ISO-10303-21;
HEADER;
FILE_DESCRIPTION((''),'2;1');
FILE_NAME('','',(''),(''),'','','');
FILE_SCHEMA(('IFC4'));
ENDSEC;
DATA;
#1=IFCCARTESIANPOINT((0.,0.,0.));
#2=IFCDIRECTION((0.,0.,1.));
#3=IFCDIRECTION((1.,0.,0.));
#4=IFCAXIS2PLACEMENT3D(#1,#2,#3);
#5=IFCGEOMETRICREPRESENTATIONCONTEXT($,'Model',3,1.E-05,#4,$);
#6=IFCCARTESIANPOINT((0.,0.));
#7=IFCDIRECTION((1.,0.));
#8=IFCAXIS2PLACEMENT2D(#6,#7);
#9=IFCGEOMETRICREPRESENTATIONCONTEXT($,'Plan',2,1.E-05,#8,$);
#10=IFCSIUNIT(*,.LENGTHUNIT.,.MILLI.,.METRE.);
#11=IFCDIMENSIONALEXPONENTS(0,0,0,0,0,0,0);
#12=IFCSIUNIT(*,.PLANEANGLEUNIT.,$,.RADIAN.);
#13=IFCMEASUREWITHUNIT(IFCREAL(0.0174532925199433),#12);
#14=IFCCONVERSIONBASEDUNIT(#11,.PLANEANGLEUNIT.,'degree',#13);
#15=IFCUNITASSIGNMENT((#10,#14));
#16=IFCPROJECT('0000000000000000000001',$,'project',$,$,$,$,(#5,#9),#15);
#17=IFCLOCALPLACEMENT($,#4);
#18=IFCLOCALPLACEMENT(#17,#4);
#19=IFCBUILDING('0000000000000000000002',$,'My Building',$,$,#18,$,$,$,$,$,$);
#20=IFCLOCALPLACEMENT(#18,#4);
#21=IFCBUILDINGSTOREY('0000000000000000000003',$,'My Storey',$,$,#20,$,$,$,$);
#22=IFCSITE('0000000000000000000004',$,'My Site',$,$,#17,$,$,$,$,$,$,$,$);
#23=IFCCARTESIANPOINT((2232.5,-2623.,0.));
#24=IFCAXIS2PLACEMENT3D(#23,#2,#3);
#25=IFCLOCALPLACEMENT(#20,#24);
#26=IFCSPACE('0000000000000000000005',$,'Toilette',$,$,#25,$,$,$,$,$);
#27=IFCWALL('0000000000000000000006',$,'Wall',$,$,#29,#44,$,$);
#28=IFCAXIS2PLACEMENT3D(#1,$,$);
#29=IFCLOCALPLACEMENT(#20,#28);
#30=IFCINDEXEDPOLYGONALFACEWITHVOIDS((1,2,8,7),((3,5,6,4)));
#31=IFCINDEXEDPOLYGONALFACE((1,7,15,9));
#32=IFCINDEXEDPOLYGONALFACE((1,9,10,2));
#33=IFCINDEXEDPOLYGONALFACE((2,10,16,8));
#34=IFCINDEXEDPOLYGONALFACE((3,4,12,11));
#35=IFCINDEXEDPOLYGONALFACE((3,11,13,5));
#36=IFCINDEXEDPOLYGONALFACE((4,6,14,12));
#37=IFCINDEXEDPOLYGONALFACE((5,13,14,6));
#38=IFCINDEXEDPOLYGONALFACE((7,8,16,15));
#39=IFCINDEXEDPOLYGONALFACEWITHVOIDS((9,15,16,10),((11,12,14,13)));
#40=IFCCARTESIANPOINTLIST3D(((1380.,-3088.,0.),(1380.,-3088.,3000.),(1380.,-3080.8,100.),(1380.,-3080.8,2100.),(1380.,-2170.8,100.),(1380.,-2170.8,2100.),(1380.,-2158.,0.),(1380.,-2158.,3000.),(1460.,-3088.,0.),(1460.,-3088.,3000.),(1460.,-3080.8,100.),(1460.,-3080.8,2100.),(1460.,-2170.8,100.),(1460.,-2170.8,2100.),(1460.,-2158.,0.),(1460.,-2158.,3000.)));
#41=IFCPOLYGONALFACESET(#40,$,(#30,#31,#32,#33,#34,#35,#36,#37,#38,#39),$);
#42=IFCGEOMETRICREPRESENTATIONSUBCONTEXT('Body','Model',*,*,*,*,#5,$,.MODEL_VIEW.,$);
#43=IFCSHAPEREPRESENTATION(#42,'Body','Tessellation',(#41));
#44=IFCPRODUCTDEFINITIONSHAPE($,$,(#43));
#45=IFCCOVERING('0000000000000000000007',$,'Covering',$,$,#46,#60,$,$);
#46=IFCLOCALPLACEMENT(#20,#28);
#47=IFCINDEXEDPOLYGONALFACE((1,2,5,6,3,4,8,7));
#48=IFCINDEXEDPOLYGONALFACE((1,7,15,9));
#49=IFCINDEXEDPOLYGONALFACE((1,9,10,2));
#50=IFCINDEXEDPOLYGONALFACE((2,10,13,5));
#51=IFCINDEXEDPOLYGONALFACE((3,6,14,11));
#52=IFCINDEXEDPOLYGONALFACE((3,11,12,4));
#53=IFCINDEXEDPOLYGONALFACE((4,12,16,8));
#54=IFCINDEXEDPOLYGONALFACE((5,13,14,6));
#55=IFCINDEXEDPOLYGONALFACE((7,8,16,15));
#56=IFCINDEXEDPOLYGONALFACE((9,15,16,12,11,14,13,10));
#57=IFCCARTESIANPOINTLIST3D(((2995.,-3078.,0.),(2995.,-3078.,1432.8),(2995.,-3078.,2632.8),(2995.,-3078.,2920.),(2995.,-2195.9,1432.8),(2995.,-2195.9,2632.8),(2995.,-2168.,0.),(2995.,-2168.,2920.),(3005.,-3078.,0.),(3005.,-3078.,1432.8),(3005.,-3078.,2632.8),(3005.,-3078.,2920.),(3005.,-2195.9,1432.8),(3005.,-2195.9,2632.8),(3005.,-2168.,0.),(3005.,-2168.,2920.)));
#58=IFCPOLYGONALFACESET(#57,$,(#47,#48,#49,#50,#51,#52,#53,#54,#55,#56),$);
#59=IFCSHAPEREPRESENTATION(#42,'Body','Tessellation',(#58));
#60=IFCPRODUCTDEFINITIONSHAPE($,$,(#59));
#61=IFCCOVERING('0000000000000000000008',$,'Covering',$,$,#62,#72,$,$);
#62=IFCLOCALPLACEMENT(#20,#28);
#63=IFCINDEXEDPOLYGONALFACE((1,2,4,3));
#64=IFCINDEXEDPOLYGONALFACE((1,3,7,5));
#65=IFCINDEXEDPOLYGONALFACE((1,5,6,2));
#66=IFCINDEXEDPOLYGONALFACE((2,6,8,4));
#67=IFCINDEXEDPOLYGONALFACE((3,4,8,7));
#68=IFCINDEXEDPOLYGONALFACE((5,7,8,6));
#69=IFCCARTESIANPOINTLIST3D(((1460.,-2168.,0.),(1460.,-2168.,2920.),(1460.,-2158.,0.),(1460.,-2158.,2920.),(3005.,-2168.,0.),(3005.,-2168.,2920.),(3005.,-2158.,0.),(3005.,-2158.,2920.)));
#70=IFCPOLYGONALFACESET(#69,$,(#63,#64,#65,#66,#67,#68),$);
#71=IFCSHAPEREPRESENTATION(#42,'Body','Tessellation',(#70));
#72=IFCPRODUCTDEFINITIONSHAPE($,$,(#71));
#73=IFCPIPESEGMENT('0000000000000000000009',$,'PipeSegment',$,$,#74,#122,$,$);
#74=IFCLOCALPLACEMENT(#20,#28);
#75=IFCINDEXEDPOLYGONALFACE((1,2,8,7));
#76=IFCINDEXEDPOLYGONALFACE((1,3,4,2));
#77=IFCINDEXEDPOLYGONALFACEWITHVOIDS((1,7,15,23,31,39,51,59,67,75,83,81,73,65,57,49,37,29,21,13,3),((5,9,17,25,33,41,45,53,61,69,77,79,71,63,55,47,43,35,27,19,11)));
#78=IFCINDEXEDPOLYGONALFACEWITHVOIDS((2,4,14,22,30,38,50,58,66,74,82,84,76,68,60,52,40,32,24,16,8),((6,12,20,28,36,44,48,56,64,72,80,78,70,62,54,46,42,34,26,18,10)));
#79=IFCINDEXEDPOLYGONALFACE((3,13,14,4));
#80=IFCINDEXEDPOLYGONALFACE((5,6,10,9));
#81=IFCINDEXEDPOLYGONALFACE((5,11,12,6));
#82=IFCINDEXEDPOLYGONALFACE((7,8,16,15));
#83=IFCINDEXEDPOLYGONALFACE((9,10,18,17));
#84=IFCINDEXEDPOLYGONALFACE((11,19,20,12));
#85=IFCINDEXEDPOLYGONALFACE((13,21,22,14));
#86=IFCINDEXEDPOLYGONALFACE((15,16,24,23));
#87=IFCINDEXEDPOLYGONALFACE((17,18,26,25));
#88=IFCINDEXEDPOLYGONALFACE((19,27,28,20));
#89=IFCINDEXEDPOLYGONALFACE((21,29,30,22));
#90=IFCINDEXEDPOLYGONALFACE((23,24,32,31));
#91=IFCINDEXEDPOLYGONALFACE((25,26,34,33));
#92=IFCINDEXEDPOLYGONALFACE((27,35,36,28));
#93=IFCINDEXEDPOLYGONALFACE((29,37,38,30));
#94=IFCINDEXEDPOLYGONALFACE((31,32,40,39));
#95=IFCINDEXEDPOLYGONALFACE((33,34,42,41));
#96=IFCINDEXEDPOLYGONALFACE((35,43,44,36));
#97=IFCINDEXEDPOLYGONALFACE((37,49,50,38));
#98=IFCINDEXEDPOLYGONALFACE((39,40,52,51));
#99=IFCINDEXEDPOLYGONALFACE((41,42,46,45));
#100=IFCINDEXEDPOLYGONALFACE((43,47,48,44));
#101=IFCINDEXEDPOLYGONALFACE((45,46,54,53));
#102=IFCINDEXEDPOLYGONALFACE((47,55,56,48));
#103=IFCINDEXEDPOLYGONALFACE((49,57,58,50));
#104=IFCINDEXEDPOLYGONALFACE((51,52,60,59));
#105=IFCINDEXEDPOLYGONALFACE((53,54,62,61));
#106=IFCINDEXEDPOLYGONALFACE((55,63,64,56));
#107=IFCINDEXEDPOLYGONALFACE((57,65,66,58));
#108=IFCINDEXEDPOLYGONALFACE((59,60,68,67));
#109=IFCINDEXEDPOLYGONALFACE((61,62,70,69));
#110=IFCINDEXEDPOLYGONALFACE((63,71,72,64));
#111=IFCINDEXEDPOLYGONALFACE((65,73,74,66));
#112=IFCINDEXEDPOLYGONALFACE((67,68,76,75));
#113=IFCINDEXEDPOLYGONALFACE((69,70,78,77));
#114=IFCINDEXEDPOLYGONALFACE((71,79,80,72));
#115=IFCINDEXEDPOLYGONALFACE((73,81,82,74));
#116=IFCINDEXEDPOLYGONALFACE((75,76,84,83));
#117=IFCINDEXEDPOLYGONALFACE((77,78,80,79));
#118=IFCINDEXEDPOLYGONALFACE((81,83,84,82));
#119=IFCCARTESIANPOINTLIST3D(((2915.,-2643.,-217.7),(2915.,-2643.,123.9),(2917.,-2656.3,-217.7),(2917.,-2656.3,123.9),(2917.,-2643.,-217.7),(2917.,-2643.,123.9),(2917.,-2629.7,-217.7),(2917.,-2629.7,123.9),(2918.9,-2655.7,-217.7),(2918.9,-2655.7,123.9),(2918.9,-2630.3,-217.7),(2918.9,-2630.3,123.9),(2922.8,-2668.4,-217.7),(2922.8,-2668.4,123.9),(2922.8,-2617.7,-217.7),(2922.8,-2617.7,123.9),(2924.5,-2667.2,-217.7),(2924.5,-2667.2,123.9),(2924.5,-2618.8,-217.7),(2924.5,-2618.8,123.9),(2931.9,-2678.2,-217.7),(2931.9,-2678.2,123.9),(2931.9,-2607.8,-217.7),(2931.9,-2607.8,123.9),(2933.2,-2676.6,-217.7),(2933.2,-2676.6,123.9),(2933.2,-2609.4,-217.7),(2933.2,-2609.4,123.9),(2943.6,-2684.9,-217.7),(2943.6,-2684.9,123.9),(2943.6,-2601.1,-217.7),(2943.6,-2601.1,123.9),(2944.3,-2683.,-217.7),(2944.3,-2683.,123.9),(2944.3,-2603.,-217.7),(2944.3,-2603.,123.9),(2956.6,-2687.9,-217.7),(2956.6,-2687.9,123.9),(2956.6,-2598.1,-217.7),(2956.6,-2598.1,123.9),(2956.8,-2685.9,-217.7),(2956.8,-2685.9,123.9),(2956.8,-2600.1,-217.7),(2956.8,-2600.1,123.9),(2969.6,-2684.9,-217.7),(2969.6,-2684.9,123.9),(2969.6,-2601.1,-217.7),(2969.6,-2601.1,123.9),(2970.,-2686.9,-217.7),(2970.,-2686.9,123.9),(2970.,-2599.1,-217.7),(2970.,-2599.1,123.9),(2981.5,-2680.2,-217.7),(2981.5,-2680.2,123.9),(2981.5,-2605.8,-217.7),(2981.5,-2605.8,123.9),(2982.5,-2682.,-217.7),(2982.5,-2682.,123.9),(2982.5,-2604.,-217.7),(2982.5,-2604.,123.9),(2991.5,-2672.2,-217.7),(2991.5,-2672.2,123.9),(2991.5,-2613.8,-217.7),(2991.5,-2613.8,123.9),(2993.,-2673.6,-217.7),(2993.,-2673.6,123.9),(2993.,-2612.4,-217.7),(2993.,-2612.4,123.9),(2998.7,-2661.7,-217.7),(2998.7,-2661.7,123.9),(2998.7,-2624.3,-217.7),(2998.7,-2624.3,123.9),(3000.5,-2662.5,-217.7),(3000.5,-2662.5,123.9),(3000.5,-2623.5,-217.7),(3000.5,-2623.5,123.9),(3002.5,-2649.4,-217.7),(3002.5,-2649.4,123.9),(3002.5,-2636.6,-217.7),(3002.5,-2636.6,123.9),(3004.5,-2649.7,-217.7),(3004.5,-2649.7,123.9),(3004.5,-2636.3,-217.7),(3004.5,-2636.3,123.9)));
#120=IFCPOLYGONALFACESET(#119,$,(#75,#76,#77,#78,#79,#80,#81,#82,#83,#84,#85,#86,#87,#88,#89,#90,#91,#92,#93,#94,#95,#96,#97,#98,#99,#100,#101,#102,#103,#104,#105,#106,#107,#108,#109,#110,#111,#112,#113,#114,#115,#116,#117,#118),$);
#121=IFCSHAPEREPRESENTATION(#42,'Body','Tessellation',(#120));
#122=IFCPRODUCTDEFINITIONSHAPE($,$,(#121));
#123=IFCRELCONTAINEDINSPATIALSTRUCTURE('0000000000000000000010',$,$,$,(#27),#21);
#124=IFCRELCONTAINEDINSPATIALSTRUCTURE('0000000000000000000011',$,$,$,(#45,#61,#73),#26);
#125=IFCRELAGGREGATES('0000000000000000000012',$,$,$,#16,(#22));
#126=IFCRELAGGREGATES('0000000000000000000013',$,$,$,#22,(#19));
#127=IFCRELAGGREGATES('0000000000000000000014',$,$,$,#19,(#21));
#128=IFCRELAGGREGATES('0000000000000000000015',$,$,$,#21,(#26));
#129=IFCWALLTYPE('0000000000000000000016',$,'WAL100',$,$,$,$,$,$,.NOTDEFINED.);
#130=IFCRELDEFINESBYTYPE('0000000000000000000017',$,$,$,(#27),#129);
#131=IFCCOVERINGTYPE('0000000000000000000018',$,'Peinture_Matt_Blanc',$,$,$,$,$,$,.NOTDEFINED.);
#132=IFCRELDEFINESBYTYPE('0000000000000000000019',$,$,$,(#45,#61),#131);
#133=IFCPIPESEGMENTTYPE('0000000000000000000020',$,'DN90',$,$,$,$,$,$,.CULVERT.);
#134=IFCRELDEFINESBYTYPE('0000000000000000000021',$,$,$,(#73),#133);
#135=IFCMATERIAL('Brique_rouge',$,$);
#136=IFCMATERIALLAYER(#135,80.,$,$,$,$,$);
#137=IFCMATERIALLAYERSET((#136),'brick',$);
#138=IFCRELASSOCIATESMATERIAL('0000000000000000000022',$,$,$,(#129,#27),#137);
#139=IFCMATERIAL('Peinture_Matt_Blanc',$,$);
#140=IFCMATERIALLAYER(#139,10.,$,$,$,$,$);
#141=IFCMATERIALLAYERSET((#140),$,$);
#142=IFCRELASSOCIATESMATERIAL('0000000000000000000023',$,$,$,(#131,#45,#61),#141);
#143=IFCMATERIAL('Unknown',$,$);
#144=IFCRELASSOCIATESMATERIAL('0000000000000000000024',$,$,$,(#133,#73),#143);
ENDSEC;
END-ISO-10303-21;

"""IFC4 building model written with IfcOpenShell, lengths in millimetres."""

from ifc_helpers import new_model, entity, si_unit, converted_unit, frame, origin_with_axes, origin_2d_with_axis, place, context, subcontext, project, spatial, line, indexed_curve, hollow_circle, outline, extrude, clip, halfspace, source, transform, mapped, material, layer, layer_set, layer_usage, material_profile, profile_set, profile_usage, type_object, element, save


model = new_model("IFC4")

# Units and contexts
model_context = context("Model", 3, precision=1e-05, world=origin_with_axes())
plan_context = context("Plan", 2, precision=1e-05, world=origin_2d_with_axis())
body_context = subcontext(model_context, "Body", "Model", "MODEL_VIEW")
ifc_project = project(units=[si_unit("LENGTHUNIT", "METRE", prefix="MILLI"), converted_unit("PLANEANGLEUNIT", "degree", entity("IfcReal", 0.0174532925199433), si_unit("PLANEANGLEUNIT", "RADIAN"), dimensions=[0, 0, 0, 0, 0, 0, 0])], contexts=[model_context, plan_context])

# Site, building, storey
site_placement = place(None, origin_with_axes())
site = spatial("IfcSite", under=ifc_project, at=site_placement, Name="My Site")
building_placement = place(site_placement, origin_with_axes())
building = spatial("IfcBuilding", under=site, at=building_placement, Name="My Building")
storey_placement = place(building_placement, origin_with_axes())
storey = spatial("IfcBuildingStorey", under=building, at=storey_placement, Name="My Storey")

# Shared definitions
ifc_material_1 = material(Name="Unknown")

# Wall, opening
ifc_material_2 = material(Name="Brique_rouge")
ifc_layer_1 = layer(ifc_material_2, 80.0)
ifc_layer_set_1 = layer_set([ifc_layer_1], Name="brick")
ifc_layer_usage_1 = layer_usage(ifc_layer_set_1, "AXIS2", "POSITIVE", 0.0)
wall_type = type_object("IfcWallType", Name="WAL100", PredefinedType="NOTDEFINED", material=ifc_layer_set_1)
wall_placement = place(storey_placement, frame((1380.0, -2158.0, 0.0), z_axis=(0.0, 0.0, 1.0), x_axis=(-0.000001, -1.0, 0.0)))
wall = element("IfcWall", 1, at=wall_placement, inside=storey, type_object=wall_type, material=ifc_layer_usage_1, Name="Wall", context=body_context, shape_type="SweptSolid", body=[
    extrude(outline(indexed_curve([(0.0, 0.0), (0.0, 80.0), (930.0, 80.0), (930.0, 0.0), (0.0, 0.0)], self_intersect=False)), origin_with_axes(), (0.0, 0.0, 1.0), 3000.0),
])
shared_shape_1 = source(origin_with_axes(), body_context, "Body", "SweptSolid", [
    extrude(outline(indexed_curve([(0.0, 0.0), (910.0, 0.0), (910.0, 2000.0), (0.0, 2000.0)], segments=[line(3, 2), line(2, 1), line(1, 4), line(4, 3)], self_intersect=False)), frame((0.0, -100.0, 0.0), z_axis=(0.0, -1.0, 0.0), x_axis=(1.0, 0.0, 0.0)), (0.0, 0.0, -1.0), 280.0),
])
opening_1_placement = place(wall_placement, frame((12.8, -13.4, 100.0), z_axis=(0.0, 0.0, 1.0), x_axis=(1.0, 0.0, 0.0)))
element("IfcOpeningElement", 2, at=opening_1_placement, cuts=wall, PredefinedType="OPENING", context=body_context, shape_type="MappedRepresentation", body=[
    mapped(shared_shape_1, transform((0.0, 0.0, 0.0), x_axis=(1.0, 0.0, 0.0), y_axis=(0.0, 1.0, 0.0), z_axis=(0.0, 0.0, 1.0), scale=1.0)),
])

# Shared definitions
space_1_placement = place(storey_placement, frame((2232.5, -2623.0, 0.0), z_axis=(0.0, 0.0, 1.0), x_axis=(1.0, 0.0, 0.0)))
space_1 = spatial("IfcSpace", under=storey, at=space_1_placement, Name="Toilette")

# Covering, opening
ifc_material_3 = material(Name="Peinture_Matt_Blanc")
ifc_layer_2 = layer(ifc_material_3, 10.0)
ifc_layer_set_2 = layer_set([ifc_layer_2])
ifc_layer_usage_2 = layer_usage(ifc_layer_set_2, "AXIS2", "POSITIVE", 0.0)
covering_type_1 = type_object("IfcCoveringType", Name="Peinture_Matt_Blanc", PredefinedType="NOTDEFINED", material=ifc_layer_set_2)
covering_1_placement = place(space_1_placement, frame((762.5, 455.0, 0.0), z_axis=(0.0, 0.0, 1.0), x_axis=(-0.000001, -1.0, 0.0)))
covering_1 = element("IfcCovering", 3, at=covering_1_placement, inside=space_1, type_object=covering_type_1, material=ifc_layer_usage_2, Name="Covering", context=body_context, shape_type="Clipping", body=[
    clip(extrude(outline(indexed_curve([(0.0, 0.0), (0.0, 10.0), (910.0, 10.0), (910.0, 0.0), (0.0, 0.0)], self_intersect=False)), origin_with_axes(), (0.0, 0.0, 1.0), 2920.0), halfspace(frame((0.0, 0.0, 2920.0), z_axis=(0.0, 0.0, 1.0), x_axis=(-1.0, 0.0, 0.0)), False)),
])
shared_shape_2 = source(origin_with_axes(), body_context, "Body", "SweptSolid", [
    extrude(outline(indexed_curve([(0.0, 0.0), (900.0, 0.0), (900.0, 1200.0), (0.0, 1200.0)], segments=[line(1, 2, 3, 4, 1)])), frame((0.0, -600.0, 0.0), z_axis=(0.0, -1.0, 0.0), x_axis=(1.0, 0.0, 0.0)), (0.0, 0.0, -1.0), 1200.0),
])
opening_2_placement = place(covering_1_placement, frame((27.9, 10.0, 1432.8), z_axis=(0.0, 0.0, 1.0), x_axis=(1.0, 0.0, 0.0)))
element("IfcOpeningElement", 4, at=opening_2_placement, cuts=covering_1, PredefinedType="OPENING", context=body_context, shape_type="MappedRepresentation", body=[
    mapped(shared_shape_2, transform((0.0, 0.0, 0.0), x_axis=(1.0, 0.0, 0.0), y_axis=(0.0, 1.0, 0.0), z_axis=(0.0, 0.0, 1.0), scale=1.0)),
])

# Covering
ifc_layer_usage_3 = layer_usage(ifc_layer_set_2, "AXIS2", "POSITIVE", 0.0)
covering_2_placement = place(space_1_placement, frame((772.5, 465.0, 0.0), z_axis=(0.0, 0.0, 1.0), x_axis=(-1.0, 0.000002, 0.0)))
element("IfcCovering", 5, at=covering_2_placement, inside=space_1, type_object=covering_type_1, material=ifc_layer_usage_3, Name="Covering", context=body_context, shape_type="Clipping", body=[
    clip(extrude(outline(indexed_curve([(0.0, 0.0), (0.0, 10.0), (1545.0, 10.0), (1545.0, 0.0), (0.0, 0.0)], self_intersect=False)), origin_with_axes(), (0.0, 0.0, 1.0), 2920.0), halfspace(frame((0.0, 0.0, 2920.0), z_axis=(0.0, 0.0, 1.0), x_axis=(-1.0, 0.0, 0.0)), False)),
])

# Pipe segment
ifc_material_profile_1 = material_profile(ifc_material_1, hollow_circle(Radius=45.0, WallThickness=2.0))
ifc_profile_set_1 = profile_set([ifc_material_profile_1])
pipe_segment_type_1 = type_object("IfcPipeSegmentType", Name="DN90", PredefinedType="CULVERT", material=ifc_profile_set_1)
ifc_profile_usage_1 = profile_usage(ifc_profile_set_1, cardinal=5)
pipe_segment_1_placement = place(space_1_placement, frame((727.5, -20.0, 123.9), z_axis=(0.0, 0.0, -1.0), x_axis=(-1.0, 0.0, 0.0)))
element("IfcPipeSegment", 6, at=pipe_segment_1_placement, inside=space_1, type_object=pipe_segment_type_1, material=ifc_profile_usage_1, Name="PipeSegment", context=body_context, shape_type="SweptSolid", body=[
    extrude(hollow_circle(Radius=45.0, WallThickness=2.0), origin_with_axes(), (0.0, 0.0, 1.0), 341.5),
])

save(model, "model.ifc")
